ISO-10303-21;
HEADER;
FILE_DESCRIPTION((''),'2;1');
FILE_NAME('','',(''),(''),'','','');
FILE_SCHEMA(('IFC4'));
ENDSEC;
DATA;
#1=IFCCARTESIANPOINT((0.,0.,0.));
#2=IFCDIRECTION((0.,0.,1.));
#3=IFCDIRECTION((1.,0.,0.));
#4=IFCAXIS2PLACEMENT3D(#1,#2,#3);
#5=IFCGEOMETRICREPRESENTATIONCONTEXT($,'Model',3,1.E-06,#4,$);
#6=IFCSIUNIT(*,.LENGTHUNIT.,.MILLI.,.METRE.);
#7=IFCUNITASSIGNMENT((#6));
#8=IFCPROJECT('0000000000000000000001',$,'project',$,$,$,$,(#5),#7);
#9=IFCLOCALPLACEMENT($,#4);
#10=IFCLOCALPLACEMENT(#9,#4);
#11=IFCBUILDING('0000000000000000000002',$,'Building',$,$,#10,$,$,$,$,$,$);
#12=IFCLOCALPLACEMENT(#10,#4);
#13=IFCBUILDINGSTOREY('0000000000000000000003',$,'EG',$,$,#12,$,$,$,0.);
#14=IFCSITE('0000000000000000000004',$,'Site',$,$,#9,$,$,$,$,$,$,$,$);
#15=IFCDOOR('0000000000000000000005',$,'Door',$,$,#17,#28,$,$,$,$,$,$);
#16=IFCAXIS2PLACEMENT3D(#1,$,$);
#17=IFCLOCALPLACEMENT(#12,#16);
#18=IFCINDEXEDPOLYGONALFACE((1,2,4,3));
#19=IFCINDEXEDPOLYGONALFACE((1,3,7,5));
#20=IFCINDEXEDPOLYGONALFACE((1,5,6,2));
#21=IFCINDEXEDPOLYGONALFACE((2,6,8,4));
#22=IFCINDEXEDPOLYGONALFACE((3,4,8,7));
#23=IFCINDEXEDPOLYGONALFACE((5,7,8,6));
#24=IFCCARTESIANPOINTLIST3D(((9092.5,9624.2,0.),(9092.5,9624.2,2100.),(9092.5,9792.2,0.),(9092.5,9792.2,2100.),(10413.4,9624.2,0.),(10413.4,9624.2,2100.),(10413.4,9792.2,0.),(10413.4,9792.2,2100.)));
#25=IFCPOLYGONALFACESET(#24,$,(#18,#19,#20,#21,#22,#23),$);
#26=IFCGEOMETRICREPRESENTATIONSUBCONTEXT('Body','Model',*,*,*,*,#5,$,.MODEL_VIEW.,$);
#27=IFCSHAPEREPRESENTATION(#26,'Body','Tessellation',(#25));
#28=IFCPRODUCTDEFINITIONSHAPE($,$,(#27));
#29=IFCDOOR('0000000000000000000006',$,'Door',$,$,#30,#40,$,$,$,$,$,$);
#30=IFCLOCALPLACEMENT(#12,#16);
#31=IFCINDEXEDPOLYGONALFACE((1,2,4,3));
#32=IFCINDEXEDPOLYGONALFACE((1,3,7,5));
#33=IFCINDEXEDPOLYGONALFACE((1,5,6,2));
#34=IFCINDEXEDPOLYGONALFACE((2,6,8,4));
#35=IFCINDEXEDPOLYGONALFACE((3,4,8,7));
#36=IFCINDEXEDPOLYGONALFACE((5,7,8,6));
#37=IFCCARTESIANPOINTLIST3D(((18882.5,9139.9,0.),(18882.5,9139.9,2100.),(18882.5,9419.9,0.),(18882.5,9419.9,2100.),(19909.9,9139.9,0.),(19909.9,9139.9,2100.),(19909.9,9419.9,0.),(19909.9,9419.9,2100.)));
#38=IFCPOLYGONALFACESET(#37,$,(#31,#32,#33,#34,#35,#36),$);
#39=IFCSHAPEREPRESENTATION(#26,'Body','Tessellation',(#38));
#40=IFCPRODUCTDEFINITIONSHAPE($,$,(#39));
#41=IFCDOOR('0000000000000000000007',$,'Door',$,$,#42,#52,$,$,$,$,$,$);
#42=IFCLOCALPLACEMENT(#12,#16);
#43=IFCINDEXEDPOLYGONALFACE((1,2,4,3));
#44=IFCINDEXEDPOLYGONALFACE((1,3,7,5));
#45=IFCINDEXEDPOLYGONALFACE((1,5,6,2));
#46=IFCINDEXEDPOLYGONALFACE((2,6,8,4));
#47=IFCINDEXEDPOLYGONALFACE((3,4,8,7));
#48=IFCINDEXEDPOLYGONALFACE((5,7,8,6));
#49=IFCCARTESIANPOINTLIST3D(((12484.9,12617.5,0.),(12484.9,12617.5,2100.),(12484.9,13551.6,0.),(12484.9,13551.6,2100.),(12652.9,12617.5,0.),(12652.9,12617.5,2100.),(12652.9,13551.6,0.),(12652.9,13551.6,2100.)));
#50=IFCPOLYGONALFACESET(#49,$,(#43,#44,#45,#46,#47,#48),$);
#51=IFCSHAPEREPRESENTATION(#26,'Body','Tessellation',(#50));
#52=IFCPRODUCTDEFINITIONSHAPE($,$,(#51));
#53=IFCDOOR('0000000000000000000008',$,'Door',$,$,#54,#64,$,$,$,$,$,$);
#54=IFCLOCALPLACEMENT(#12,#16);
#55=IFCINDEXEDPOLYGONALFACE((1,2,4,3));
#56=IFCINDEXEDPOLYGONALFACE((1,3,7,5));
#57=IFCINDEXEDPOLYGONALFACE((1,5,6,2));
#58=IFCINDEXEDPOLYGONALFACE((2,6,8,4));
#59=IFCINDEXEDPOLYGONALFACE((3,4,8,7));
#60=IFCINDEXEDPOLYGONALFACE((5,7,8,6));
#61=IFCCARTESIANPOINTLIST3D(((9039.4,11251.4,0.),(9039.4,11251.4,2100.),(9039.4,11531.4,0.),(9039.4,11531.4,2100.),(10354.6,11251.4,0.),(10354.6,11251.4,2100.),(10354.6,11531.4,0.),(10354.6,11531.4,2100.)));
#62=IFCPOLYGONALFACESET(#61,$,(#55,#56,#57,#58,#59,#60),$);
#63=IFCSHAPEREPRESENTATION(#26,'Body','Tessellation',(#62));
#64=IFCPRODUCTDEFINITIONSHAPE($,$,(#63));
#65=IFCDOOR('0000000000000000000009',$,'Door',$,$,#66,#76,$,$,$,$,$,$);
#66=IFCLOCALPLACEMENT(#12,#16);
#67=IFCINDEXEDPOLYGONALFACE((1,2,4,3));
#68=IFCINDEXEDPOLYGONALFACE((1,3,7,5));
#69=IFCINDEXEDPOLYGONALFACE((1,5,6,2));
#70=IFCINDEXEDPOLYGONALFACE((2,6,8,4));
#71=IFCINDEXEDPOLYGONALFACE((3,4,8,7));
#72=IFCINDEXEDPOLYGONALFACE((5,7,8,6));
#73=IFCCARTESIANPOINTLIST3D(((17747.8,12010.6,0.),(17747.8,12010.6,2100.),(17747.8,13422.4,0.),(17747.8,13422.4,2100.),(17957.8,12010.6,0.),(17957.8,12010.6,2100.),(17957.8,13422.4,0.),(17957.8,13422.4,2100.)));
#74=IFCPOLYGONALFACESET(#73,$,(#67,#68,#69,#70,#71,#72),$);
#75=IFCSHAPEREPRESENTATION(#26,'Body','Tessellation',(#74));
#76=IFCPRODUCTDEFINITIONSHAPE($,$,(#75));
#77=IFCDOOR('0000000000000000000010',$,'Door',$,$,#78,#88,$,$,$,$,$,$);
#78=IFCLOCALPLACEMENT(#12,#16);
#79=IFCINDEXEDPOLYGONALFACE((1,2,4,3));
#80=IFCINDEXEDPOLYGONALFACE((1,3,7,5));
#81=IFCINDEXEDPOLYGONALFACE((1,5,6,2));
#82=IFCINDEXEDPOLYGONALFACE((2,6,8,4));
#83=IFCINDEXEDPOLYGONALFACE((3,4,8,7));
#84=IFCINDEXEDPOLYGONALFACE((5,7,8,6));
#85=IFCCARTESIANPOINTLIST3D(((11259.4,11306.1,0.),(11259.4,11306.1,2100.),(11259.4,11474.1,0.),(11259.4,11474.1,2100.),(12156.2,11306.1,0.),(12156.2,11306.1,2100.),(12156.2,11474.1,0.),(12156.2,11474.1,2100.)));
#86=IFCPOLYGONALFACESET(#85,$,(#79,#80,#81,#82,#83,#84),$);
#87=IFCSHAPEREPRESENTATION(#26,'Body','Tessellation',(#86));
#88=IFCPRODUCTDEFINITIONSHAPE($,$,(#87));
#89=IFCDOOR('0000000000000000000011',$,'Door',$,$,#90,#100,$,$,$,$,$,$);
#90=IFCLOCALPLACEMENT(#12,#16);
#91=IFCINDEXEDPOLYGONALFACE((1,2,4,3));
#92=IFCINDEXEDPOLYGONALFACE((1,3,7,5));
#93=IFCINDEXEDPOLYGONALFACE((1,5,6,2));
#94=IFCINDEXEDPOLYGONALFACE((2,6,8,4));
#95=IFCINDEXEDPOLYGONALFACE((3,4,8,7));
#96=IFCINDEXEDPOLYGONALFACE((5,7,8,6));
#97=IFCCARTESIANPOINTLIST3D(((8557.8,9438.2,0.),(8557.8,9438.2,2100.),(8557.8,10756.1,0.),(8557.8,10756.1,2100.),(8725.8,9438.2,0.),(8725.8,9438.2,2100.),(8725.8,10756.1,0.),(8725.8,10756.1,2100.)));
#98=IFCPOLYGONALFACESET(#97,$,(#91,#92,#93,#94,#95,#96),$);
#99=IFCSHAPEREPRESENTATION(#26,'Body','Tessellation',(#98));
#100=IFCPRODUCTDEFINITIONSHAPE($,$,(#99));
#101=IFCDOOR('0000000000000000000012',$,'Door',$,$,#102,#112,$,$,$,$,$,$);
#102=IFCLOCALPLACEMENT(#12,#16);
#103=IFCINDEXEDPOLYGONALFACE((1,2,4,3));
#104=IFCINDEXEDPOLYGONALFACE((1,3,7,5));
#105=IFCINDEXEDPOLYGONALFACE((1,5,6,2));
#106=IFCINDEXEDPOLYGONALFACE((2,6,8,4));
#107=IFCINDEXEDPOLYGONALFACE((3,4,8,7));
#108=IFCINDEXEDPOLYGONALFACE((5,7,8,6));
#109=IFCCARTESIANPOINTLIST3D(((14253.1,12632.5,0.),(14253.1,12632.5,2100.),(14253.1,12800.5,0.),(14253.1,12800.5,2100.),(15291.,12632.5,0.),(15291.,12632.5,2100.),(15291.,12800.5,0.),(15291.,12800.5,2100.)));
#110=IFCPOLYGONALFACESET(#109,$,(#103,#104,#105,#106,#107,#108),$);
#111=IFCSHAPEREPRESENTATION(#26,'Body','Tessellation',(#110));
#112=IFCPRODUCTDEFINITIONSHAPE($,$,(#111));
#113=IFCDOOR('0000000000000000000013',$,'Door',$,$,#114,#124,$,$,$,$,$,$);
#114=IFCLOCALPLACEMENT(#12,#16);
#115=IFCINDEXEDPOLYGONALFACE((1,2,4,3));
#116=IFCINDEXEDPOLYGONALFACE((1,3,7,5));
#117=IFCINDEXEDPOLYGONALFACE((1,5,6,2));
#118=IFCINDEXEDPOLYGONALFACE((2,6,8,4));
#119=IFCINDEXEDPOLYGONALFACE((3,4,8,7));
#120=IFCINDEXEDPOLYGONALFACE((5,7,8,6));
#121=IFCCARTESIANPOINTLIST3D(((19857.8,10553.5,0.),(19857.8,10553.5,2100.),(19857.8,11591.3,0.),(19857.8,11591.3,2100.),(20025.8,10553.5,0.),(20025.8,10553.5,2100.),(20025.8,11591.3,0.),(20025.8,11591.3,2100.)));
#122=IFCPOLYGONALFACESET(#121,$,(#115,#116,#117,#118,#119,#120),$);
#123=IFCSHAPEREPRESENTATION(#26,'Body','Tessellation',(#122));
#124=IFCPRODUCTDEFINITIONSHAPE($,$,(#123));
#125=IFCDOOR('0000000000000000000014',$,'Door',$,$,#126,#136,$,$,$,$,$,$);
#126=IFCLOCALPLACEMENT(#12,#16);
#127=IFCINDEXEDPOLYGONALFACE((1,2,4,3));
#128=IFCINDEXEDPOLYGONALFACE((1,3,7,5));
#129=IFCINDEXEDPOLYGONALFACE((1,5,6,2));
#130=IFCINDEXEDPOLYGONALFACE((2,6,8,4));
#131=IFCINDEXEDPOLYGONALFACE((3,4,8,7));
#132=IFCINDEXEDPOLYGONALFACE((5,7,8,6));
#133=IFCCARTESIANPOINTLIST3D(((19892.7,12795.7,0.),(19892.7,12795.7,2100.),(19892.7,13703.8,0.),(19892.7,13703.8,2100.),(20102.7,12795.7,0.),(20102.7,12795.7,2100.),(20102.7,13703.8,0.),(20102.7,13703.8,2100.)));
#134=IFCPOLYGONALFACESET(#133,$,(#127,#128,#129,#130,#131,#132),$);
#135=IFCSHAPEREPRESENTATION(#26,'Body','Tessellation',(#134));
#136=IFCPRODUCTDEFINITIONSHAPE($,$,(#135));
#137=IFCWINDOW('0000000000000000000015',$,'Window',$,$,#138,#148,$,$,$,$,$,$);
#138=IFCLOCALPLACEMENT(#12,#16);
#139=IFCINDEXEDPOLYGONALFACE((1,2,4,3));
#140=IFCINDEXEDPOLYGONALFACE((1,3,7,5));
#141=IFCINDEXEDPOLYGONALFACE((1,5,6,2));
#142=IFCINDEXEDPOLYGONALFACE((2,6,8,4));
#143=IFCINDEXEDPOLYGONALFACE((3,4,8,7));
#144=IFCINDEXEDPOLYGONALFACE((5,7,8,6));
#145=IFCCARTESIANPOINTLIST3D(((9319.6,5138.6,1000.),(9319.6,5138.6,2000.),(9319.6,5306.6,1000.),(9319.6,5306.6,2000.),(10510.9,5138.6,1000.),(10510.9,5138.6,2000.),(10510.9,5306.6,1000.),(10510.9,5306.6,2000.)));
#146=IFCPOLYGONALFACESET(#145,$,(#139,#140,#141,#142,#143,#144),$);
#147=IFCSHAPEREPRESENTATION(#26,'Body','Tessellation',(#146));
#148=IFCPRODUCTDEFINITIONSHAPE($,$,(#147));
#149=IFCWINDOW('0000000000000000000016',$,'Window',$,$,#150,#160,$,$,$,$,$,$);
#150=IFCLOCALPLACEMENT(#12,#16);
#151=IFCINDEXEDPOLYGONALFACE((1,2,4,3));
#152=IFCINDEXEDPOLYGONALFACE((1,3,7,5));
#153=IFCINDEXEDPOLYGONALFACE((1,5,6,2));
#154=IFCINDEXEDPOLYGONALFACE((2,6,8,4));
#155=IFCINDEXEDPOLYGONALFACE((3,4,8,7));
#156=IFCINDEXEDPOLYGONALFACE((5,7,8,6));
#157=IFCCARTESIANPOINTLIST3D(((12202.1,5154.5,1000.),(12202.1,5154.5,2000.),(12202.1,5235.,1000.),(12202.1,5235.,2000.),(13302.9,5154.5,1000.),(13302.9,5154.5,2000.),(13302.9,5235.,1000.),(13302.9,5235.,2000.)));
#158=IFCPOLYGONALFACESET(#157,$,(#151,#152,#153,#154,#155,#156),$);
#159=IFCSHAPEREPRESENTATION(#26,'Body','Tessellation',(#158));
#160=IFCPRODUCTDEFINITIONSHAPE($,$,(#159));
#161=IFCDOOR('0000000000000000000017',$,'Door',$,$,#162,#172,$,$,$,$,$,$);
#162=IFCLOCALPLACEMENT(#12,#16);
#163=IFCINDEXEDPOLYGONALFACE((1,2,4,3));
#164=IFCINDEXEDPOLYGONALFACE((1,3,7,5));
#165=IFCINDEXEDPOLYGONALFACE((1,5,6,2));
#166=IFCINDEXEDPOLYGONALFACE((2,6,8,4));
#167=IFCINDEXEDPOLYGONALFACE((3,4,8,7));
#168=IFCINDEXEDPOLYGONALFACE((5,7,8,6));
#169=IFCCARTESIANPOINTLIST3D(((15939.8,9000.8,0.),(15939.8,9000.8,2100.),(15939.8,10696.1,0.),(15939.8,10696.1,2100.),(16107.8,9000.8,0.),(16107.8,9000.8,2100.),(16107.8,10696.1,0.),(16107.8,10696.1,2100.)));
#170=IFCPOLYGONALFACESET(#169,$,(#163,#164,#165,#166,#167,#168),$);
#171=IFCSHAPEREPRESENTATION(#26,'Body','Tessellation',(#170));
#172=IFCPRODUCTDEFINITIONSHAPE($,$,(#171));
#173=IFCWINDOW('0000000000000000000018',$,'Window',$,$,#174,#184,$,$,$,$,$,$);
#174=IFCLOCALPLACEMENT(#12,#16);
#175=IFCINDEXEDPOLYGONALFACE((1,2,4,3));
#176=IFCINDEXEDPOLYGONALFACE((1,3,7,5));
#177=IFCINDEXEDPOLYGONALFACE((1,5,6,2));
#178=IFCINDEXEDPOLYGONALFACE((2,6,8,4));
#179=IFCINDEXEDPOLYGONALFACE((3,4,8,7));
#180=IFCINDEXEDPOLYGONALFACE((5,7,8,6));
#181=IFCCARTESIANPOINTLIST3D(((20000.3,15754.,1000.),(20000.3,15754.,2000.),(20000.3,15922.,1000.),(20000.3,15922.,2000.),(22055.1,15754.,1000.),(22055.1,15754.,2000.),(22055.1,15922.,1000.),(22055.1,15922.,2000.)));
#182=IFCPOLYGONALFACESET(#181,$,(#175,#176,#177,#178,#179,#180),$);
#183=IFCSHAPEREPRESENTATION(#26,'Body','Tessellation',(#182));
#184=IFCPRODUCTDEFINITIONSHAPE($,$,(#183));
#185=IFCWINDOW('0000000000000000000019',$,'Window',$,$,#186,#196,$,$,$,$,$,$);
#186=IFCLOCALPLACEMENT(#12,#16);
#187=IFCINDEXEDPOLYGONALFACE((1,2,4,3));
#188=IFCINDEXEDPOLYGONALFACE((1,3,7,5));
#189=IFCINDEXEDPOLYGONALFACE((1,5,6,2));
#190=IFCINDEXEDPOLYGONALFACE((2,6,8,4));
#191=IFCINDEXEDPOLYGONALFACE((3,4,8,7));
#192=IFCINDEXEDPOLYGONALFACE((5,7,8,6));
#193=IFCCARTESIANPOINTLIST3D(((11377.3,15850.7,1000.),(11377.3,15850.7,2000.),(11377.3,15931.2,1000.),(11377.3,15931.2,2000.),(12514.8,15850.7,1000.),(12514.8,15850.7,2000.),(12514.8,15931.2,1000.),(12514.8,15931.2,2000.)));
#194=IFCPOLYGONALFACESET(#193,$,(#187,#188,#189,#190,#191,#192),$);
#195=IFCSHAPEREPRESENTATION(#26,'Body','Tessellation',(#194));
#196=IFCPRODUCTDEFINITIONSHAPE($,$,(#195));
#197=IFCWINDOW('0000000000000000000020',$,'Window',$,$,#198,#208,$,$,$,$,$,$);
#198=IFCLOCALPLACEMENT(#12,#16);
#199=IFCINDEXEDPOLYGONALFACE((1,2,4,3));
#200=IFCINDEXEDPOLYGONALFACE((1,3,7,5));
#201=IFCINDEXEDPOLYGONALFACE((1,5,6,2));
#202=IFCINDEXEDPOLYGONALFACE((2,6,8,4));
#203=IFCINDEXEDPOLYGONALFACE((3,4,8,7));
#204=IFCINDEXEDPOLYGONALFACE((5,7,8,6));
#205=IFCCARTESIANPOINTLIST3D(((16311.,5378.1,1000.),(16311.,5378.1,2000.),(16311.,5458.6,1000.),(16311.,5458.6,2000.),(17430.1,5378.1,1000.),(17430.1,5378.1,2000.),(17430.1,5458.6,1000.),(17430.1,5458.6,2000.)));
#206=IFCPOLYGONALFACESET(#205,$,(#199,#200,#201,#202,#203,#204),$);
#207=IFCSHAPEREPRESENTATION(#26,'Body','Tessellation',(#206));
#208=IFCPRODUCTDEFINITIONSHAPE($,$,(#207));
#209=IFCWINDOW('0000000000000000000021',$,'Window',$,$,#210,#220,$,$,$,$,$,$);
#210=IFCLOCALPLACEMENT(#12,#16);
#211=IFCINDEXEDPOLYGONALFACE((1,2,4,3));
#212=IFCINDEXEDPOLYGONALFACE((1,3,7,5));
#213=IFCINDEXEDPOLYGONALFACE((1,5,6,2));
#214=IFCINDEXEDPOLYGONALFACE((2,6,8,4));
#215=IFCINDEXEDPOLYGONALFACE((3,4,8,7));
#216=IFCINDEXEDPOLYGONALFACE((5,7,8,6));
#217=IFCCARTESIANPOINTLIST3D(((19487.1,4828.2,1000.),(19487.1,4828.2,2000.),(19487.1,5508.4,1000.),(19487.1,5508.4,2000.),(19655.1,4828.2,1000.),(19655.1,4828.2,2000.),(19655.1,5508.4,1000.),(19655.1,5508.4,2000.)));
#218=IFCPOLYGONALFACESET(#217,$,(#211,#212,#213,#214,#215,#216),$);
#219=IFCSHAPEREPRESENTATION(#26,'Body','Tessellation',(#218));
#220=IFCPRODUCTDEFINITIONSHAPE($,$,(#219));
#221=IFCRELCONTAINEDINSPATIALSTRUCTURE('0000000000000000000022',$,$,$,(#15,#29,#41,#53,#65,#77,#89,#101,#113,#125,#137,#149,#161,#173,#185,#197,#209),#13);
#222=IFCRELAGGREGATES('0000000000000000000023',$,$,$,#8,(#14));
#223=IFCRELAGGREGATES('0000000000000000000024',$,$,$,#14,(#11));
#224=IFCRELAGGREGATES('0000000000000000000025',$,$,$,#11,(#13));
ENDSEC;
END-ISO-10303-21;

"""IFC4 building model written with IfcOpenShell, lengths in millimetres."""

from ifc_helpers import new_model, si_unit, frame, origin_with_axes, place, context, subcontext, project, spatial, rectangle, extrude, element, save


model = new_model("IFC4")

# Units and contexts
model_context = context("Model", 3, precision=1e-06, world=origin_with_axes())
body_context = subcontext(model_context, "Body", "Model", "MODEL_VIEW")
ifc_project = project(units=[si_unit("LENGTHUNIT", "METRE", prefix="MILLI")], contexts=[model_context])

# Site, building, storey
site_placement = place(None, origin_with_axes())
site = spatial("IfcSite", under=ifc_project, at=site_placement, Name="Site")
building_placement = place(site_placement, origin_with_axes())
building = spatial("IfcBuilding", under=site, at=building_placement, Name="Building")
storey_placement = place(building_placement, origin_with_axes())
storey = spatial("IfcBuildingStorey", under=building, at=storey_placement, Name="EG", Elevation=0.0)

# Doors
door_1_placement = place(storey_placement, origin_with_axes())
element("IfcDoor", 1, at=door_1_placement, inside=storey, Name="Door", context=body_context, shape_type="SweptSolid", body=[
    extrude(rectangle(XDim=1321.0, YDim=168.0), frame((9753.0, 9708.2, 0.0), z_axis=(0.0, 0.0, 1.0), x_axis=(1.0, 0.0, 0.0)), (0.0, 0.0, 1.0), 2100.0),
])
door_2_placement = place(storey_placement, origin_with_axes())
element("IfcDoor", 2, at=door_2_placement, inside=storey, Name="Door", context=body_context, shape_type="SweptSolid", body=[
    extrude(rectangle(XDim=1027.4, YDim=280.0), frame((19396.2, 9279.9, 0.0), z_axis=(0.0, 0.0, 1.0), x_axis=(1.0, 0.0, 0.0)), (0.0, 0.0, 1.0), 2100.0),
])
door_3_placement = place(storey_placement, origin_with_axes())
element("IfcDoor", 3, at=door_3_placement, inside=storey, Name="Door", context=body_context, shape_type="SweptSolid", body=[
    extrude(rectangle(XDim=934.1, YDim=168.0), frame((12568.9, 13084.5, 0.0), z_axis=(0.0, 0.0, 1.0), x_axis=(0.0, 1.0, 0.0)), (0.0, 0.0, 1.0), 2100.0),
])
door_4_placement = place(storey_placement, origin_with_axes())
element("IfcDoor", 4, at=door_4_placement, inside=storey, Name="Door", context=body_context, shape_type="SweptSolid", body=[
    extrude(rectangle(XDim=1315.2, YDim=280.0), frame((9697.0, 11391.4, 0.0), z_axis=(0.0, 0.0, 1.0), x_axis=(1.0, 0.0, 0.0)), (0.0, 0.0, 1.0), 2100.0),
])
door_5_placement = place(storey_placement, origin_with_axes())
element("IfcDoor", 5, at=door_5_placement, inside=storey, Name="Door", context=body_context, shape_type="SweptSolid", body=[
    extrude(rectangle(XDim=1411.9, YDim=210.0), frame((17852.8, 12716.5, 0.0), z_axis=(0.0, 0.0, 1.0), x_axis=(0.0, 1.0, 0.0)), (0.0, 0.0, 1.0), 2100.0),
])
door_6_placement = place(storey_placement, origin_with_axes())
element("IfcDoor", 6, at=door_6_placement, inside=storey, Name="Door", context=body_context, shape_type="SweptSolid", body=[
    extrude(rectangle(XDim=896.8, YDim=168.0), frame((11707.8, 11390.1, 0.0), z_axis=(0.0, 0.0, 1.0), x_axis=(1.0, 0.0, 0.0)), (0.0, 0.0, 1.0), 2100.0),
])
door_7_placement = place(storey_placement, origin_with_axes())
element("IfcDoor", 7, at=door_7_placement, inside=storey, Name="Door", context=body_context, shape_type="SweptSolid", body=[
    extrude(rectangle(XDim=1317.9, YDim=168.0), frame((8641.8, 10097.1, 0.0), z_axis=(0.0, 0.0, 1.0), x_axis=(0.0, 1.0, 0.0)), (0.0, 0.0, 1.0), 2100.0),
])
door_8_placement = place(storey_placement, origin_with_axes())
element("IfcDoor", 8, at=door_8_placement, inside=storey, Name="Door", context=body_context, shape_type="SweptSolid", body=[
    extrude(rectangle(XDim=1037.8, YDim=168.0), frame((14772.0, 12716.5, 0.0), z_axis=(0.0, 0.0, 1.0), x_axis=(1.0, 0.0, 0.0)), (0.0, 0.0, 1.0), 2100.0),
])
door_9_placement = place(storey_placement, origin_with_axes())
element("IfcDoor", 9, at=door_9_placement, inside=storey, Name="Door", context=body_context, shape_type="SweptSolid", body=[
    extrude(rectangle(XDim=1037.8, YDim=168.0), frame((19941.8, 11072.4, 0.0), z_axis=(0.0, 0.0, 1.0), x_axis=(0.0, 1.0, 0.0)), (0.0, 0.0, 1.0), 2100.0),
])
door_10_placement = place(storey_placement, origin_with_axes())
element("IfcDoor", 10, at=door_10_placement, inside=storey, Name="Door", context=body_context, shape_type="SweptSolid", body=[
    extrude(rectangle(XDim=908.1, YDim=210.0), frame((19997.7, 13249.8, 0.0), z_axis=(0.0, 0.0, 1.0), x_axis=(0.0, 1.0, 0.0)), (0.0, 0.0, 1.0), 2100.0),
])

# Windows
window_1_placement = place(storey_placement, origin_with_axes())
element("IfcWindow", 11, at=window_1_placement, inside=storey, Name="Window", context=body_context, shape_type="SweptSolid", body=[
    extrude(rectangle(XDim=1191.3, YDim=168.0), frame((9915.3, 5222.6, 1000.0), z_axis=(0.0, 0.0, 1.0), x_axis=(1.0, 0.0, 0.0)), (0.0, 0.0, 1.0), 1000.0),
])
window_2_placement = place(storey_placement, origin_with_axes())
element("IfcWindow", 12, at=window_2_placement, inside=storey, Name="Window", context=body_context, shape_type="SweptSolid", body=[
    extrude(rectangle(XDim=1100.8, YDim=80.5), frame((12752.5, 5194.8, 1000.0), z_axis=(0.0, 0.0, 1.0), x_axis=(1.0, 0.0, 0.0)), (0.0, 0.0, 1.0), 1000.0),
])

# Door
door_11_placement = place(storey_placement, origin_with_axes())
element("IfcDoor", 13, at=door_11_placement, inside=storey, Name="Door", context=body_context, shape_type="SweptSolid", body=[
    extrude(rectangle(XDim=1695.3, YDim=168.0), frame((16023.8, 9848.4, 0.0), z_axis=(0.0, 0.0, 1.0), x_axis=(0.0, 1.0, 0.0)), (0.0, 0.0, 1.0), 2100.0),
])

# Windows
window_3_placement = place(storey_placement, origin_with_axes())
element("IfcWindow", 14, at=window_3_placement, inside=storey, Name="Window", context=body_context, shape_type="SweptSolid", body=[
    extrude(rectangle(XDim=2054.8, YDim=168.0), frame((21027.7, 15838.0, 1000.0), z_axis=(0.0, 0.0, 1.0), x_axis=(1.0, 0.0, 0.0)), (0.0, 0.0, 1.0), 1000.0),
])
window_4_placement = place(storey_placement, origin_with_axes())
element("IfcWindow", 15, at=window_4_placement, inside=storey, Name="Window", context=body_context, shape_type="SweptSolid", body=[
    extrude(rectangle(XDim=1137.5, YDim=80.5), frame((11946.1, 15891.0, 1000.0), z_axis=(0.0, 0.0, 1.0), x_axis=(1.0, 0.0, 0.0)), (0.0, 0.0, 1.0), 1000.0),
])
window_5_placement = place(storey_placement, origin_with_axes())
element("IfcWindow", 16, at=window_5_placement, inside=storey, Name="Window", context=body_context, shape_type="SweptSolid", body=[
    extrude(rectangle(XDim=1119.1, YDim=80.5), frame((16870.6, 5418.3, 1000.0), z_axis=(0.0, 0.0, 1.0), x_axis=(1.0, 0.0, 0.0)), (0.0, 0.0, 1.0), 1000.0),
])
window_6_placement = place(storey_placement, origin_with_axes())
element("IfcWindow", 17, at=window_6_placement, inside=storey, Name="Window", context=body_context, shape_type="SweptSolid", body=[
    extrude(rectangle(XDim=680.2, YDim=168.0), frame((19571.1, 5168.3, 1000.0), z_axis=(0.0, 0.0, 1.0), x_axis=(0.0, 1.0, 0.0)), (0.0, 0.0, 1.0), 1000.0),
])

save(model, "model.ifc")
